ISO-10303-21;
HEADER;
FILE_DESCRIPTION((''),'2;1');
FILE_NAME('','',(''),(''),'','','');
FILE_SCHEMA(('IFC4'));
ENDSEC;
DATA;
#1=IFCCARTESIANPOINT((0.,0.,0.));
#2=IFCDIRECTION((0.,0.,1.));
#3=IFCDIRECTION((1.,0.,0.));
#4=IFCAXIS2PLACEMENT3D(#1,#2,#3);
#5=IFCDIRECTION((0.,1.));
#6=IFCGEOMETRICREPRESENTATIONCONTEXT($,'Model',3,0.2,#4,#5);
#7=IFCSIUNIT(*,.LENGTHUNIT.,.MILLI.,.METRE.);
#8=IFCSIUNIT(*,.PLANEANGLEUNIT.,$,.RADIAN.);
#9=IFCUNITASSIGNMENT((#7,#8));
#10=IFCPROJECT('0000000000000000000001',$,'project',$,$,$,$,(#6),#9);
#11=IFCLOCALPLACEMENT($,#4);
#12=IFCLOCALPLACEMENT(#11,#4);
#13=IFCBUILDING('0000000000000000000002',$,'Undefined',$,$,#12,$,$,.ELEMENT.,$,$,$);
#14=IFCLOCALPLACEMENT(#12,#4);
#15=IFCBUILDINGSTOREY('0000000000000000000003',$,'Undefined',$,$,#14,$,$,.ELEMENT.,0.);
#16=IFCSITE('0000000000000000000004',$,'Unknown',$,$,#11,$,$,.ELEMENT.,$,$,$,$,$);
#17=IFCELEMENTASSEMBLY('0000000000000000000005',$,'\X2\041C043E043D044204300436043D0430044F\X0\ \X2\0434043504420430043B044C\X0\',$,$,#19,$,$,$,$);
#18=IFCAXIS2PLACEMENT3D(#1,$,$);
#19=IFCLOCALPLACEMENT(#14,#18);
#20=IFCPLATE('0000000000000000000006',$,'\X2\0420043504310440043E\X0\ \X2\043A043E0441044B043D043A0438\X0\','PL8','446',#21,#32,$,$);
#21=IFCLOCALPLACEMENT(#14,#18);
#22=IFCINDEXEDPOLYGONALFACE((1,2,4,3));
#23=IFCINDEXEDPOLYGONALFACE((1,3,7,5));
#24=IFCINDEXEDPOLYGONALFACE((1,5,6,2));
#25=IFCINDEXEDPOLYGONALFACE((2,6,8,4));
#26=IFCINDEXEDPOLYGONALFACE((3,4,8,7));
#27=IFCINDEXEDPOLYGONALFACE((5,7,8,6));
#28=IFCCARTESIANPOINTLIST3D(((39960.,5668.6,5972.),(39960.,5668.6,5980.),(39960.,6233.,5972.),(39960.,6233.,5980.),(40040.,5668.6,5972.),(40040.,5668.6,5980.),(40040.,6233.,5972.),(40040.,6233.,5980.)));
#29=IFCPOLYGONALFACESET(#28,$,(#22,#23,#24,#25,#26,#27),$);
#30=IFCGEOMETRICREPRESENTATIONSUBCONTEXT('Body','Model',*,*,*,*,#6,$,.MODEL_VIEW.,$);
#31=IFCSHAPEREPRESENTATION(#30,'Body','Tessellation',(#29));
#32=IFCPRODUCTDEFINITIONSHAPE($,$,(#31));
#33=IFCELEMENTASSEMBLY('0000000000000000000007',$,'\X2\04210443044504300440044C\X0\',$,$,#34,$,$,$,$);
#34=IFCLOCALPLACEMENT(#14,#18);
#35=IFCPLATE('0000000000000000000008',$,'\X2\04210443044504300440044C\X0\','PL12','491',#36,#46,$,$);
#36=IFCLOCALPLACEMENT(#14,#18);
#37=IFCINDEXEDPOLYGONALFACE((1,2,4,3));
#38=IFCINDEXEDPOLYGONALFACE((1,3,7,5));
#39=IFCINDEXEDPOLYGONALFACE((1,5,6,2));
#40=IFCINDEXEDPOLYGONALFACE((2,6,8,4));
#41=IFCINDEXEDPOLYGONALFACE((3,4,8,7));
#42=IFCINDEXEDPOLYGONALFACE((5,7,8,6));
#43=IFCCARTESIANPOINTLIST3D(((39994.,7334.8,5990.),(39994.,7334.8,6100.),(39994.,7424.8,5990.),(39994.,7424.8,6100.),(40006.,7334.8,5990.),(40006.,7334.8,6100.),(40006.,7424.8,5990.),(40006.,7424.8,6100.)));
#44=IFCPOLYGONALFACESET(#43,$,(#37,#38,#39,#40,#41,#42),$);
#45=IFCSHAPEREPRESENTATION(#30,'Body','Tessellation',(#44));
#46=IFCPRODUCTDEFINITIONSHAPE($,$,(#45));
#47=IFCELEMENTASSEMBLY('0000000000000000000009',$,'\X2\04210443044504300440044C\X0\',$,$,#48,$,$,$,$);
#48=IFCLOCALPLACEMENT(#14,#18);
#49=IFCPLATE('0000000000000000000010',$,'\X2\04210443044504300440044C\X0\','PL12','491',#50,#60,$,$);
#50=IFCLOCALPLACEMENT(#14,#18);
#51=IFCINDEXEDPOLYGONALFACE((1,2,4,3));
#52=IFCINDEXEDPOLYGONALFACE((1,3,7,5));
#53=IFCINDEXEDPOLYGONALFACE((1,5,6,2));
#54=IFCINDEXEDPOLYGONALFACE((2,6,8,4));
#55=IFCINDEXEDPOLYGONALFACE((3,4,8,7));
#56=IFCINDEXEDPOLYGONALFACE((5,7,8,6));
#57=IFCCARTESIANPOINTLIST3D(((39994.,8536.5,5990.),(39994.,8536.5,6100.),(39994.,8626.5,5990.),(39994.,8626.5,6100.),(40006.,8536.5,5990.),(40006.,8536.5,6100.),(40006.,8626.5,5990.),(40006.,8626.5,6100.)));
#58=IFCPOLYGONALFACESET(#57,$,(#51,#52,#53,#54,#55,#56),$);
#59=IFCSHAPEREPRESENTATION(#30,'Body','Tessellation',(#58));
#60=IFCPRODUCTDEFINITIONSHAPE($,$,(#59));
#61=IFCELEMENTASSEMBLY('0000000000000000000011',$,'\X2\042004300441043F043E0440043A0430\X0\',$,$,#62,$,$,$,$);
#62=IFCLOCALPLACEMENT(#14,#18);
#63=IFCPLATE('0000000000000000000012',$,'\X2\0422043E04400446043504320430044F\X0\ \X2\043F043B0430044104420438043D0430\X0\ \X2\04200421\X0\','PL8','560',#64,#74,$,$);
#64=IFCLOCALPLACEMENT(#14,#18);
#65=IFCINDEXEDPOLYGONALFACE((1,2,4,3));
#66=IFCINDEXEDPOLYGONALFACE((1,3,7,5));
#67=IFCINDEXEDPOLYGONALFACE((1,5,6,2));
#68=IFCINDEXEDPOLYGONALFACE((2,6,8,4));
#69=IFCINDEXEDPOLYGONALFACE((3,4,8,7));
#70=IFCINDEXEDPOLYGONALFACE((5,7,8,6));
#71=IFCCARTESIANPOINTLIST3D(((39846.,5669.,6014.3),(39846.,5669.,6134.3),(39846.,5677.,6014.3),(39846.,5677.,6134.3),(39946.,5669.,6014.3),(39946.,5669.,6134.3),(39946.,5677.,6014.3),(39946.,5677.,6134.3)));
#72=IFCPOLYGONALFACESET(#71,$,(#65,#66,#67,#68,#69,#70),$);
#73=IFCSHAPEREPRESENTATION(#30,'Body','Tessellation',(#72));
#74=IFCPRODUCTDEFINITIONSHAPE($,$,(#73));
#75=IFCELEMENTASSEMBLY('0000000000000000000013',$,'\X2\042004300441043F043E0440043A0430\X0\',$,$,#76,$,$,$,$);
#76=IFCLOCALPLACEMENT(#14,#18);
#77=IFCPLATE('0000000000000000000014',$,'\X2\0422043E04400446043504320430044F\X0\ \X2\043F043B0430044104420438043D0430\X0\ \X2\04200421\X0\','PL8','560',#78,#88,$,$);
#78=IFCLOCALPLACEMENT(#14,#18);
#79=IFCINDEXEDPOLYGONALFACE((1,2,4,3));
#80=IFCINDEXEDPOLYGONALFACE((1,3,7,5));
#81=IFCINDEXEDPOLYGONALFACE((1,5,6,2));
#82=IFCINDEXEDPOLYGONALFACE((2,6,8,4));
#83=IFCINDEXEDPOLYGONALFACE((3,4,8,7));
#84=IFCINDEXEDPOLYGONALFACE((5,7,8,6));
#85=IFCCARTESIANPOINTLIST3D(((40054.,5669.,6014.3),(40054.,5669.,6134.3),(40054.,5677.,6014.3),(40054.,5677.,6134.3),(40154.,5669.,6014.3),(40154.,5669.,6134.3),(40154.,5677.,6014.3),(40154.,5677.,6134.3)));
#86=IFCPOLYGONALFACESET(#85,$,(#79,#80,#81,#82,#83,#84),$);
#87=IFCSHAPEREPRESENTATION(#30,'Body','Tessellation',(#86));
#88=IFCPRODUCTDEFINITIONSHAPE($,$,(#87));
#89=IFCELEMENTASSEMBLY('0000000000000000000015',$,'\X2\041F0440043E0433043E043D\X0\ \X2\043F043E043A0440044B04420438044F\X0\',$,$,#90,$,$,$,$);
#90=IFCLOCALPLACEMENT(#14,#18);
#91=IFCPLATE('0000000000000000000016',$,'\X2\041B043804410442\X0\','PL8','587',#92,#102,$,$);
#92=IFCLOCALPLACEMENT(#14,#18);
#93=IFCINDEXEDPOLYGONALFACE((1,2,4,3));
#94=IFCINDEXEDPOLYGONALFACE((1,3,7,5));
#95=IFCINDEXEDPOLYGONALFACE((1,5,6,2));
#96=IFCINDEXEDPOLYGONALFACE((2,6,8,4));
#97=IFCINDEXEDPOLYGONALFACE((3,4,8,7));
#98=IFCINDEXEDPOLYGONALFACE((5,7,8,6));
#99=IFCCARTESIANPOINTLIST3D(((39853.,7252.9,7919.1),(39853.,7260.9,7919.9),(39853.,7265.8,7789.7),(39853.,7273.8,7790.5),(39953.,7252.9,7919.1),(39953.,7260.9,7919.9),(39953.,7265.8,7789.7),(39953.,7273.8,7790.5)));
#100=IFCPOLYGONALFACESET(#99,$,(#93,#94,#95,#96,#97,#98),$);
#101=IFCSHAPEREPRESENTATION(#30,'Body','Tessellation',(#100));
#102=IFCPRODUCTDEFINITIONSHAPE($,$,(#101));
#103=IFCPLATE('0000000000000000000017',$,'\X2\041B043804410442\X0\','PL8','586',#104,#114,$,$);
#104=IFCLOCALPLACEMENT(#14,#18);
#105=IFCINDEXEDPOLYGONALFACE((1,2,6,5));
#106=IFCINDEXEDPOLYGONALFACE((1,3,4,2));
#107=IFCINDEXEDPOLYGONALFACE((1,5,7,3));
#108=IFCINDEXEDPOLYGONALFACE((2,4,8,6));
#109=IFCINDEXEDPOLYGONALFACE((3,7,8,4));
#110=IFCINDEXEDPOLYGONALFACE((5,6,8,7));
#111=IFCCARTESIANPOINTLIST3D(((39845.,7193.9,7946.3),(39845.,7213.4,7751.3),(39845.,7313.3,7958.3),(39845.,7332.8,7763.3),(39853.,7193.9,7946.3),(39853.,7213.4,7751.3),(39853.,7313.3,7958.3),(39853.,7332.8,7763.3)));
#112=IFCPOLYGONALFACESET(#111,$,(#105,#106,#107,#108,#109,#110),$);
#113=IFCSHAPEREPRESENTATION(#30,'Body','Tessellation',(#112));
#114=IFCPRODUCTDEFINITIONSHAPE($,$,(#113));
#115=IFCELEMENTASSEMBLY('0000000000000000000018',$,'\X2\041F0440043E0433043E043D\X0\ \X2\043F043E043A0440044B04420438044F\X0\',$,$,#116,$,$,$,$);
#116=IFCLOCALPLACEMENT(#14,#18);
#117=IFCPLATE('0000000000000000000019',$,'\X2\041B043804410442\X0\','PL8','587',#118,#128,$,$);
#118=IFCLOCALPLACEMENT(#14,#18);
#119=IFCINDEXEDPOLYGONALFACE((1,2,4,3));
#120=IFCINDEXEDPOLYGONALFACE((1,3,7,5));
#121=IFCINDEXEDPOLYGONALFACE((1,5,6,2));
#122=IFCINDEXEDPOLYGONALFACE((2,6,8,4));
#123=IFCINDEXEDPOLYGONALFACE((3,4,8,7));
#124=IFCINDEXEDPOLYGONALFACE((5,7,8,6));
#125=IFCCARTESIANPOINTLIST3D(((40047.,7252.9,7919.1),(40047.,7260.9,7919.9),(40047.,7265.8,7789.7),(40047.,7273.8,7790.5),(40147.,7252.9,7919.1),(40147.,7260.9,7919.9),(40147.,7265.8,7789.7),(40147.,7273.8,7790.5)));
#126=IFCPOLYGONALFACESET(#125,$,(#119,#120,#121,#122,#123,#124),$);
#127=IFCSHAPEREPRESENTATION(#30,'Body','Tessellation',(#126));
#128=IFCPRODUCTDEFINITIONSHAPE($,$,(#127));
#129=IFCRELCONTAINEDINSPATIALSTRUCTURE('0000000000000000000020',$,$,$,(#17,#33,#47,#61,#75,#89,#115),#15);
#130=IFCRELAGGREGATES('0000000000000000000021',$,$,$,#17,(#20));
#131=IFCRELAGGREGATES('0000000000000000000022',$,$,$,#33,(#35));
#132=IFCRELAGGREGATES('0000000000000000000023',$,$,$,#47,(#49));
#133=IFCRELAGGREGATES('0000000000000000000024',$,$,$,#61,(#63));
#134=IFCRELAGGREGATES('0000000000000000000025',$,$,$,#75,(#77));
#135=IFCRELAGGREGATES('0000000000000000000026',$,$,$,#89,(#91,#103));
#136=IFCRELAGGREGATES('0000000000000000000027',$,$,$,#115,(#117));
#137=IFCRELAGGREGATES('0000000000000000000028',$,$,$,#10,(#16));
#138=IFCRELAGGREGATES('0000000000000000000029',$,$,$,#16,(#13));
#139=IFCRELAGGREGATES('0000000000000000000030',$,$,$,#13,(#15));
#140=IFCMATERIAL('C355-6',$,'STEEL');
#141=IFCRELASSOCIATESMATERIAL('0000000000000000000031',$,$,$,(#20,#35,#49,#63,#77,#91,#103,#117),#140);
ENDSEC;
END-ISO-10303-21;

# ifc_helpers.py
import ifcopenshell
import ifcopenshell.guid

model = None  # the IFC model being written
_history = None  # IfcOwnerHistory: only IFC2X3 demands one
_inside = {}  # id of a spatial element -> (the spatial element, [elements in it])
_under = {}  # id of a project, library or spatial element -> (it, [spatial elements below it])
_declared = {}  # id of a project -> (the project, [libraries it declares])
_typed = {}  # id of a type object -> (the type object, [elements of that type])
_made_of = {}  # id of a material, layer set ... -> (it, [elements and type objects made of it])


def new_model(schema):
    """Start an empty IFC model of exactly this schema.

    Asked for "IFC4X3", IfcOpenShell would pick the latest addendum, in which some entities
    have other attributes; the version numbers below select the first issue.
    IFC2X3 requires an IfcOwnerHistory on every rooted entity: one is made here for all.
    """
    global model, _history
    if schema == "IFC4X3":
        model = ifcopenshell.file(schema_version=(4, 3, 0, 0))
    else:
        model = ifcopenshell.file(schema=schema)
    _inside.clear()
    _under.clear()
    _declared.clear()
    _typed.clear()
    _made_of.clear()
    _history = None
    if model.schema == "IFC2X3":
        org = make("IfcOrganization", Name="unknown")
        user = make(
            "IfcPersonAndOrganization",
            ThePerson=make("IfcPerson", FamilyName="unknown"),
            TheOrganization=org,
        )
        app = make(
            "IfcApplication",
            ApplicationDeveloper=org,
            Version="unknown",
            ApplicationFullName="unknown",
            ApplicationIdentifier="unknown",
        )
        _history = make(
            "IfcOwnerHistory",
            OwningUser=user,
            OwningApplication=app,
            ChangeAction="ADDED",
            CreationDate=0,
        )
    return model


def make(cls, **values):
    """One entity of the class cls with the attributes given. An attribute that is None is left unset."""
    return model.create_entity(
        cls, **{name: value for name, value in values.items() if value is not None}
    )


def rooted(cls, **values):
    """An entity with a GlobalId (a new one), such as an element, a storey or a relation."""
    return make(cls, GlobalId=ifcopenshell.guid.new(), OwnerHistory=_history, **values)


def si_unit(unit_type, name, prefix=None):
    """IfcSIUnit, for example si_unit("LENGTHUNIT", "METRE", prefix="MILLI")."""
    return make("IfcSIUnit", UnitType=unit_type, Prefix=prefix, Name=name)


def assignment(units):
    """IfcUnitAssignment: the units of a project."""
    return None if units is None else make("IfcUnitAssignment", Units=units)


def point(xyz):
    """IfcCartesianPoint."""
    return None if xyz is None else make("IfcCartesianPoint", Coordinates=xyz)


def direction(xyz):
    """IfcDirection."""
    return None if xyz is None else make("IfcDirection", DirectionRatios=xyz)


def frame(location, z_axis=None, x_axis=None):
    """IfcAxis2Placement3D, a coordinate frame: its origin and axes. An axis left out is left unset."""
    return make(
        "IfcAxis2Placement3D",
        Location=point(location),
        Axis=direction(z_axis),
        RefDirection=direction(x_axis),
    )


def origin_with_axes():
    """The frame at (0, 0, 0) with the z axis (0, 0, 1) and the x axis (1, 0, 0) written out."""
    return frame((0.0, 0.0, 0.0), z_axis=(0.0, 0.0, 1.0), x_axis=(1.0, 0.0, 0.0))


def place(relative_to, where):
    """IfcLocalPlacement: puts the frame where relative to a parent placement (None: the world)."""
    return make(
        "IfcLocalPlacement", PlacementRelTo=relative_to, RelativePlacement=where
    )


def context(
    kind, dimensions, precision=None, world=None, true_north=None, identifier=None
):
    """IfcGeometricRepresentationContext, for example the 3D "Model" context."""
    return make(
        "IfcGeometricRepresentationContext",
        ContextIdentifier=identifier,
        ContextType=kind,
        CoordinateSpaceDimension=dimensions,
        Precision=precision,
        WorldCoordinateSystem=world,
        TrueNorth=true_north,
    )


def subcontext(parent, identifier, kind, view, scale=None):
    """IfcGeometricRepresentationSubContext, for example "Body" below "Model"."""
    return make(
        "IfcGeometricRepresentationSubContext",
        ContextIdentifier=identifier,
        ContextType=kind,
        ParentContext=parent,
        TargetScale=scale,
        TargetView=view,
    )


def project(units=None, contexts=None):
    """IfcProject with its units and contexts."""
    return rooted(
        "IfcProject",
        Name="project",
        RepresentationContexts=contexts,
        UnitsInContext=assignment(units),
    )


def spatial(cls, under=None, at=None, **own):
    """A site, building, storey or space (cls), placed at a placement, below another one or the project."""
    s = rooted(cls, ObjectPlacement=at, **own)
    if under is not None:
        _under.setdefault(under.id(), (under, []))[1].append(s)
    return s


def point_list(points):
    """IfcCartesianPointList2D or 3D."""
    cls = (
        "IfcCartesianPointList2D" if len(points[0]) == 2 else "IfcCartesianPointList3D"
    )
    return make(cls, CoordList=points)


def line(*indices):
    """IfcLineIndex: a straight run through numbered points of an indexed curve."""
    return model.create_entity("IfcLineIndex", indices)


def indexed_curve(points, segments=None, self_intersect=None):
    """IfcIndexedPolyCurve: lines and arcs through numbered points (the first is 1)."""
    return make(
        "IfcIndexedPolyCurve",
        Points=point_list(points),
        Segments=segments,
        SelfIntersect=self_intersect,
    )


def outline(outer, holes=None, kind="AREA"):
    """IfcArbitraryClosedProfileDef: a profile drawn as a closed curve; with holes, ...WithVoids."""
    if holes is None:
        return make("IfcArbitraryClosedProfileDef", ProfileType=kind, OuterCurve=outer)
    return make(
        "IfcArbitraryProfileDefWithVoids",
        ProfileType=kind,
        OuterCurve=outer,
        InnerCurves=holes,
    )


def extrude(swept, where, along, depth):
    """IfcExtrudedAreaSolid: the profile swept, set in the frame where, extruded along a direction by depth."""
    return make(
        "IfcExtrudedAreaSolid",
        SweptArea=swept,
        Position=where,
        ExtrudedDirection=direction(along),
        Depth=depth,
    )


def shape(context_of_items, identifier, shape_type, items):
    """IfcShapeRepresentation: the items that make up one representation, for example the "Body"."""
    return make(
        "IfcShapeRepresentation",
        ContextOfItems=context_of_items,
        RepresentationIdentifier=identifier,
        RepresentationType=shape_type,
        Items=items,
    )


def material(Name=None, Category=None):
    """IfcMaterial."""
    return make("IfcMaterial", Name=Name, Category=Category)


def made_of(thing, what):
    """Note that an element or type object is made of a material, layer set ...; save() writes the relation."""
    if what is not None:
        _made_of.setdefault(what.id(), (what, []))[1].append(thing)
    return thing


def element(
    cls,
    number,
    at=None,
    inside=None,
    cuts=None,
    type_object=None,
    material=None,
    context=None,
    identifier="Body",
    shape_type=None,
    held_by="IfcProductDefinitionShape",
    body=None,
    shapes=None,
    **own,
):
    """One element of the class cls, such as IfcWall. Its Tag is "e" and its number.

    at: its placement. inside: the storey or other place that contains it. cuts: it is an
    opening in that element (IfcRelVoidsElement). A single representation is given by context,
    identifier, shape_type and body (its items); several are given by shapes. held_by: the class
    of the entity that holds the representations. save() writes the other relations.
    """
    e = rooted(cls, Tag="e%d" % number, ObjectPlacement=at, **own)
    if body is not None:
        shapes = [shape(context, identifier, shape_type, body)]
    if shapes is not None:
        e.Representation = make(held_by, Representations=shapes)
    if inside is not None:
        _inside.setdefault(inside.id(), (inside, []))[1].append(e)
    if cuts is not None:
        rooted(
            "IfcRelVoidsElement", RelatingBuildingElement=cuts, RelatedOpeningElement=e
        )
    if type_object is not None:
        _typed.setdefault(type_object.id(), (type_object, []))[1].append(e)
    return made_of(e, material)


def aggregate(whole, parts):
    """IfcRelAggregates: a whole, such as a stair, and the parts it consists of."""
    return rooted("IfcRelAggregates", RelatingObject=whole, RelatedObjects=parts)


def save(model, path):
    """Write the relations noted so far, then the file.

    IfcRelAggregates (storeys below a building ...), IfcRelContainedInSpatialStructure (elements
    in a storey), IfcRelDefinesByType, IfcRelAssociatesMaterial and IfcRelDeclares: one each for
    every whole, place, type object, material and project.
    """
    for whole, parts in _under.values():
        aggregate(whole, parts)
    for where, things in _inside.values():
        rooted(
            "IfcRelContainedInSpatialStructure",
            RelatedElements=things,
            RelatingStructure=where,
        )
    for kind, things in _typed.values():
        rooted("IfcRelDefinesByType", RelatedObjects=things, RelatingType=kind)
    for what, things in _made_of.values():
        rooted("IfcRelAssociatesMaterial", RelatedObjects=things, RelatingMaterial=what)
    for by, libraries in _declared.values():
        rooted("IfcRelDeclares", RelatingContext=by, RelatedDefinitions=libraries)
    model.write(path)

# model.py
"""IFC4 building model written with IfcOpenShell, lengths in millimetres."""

from ifc_helpers import new_model, si_unit, direction, frame, origin_with_axes, place, context, subcontext, project, spatial, line, indexed_curve, outline, extrude, material, element, aggregate, save


model = new_model("IFC4")

# Units and contexts
model_context = context("Model", 3, precision=0.2, world=origin_with_axes(), true_north=direction((0.0, 1.0)))
body_context = subcontext(model_context, "Body", "Model", "MODEL_VIEW")
ifc_project = project(units=[si_unit("LENGTHUNIT", "METRE", prefix="MILLI"), si_unit("PLANEANGLEUNIT", "RADIAN")], contexts=[model_context])

# Site, building, storey
site_placement = place(None, origin_with_axes())
site = spatial("IfcSite", under=ifc_project, at=site_placement, Name="Unknown", CompositionType="ELEMENT")
building_placement = place(site_placement, origin_with_axes())
building = spatial("IfcBuilding", under=site, at=building_placement, Name="Undefined", CompositionType="ELEMENT")
storey_placement = place(building_placement, origin_with_axes())
storey = spatial("IfcBuildingStorey", under=building, at=storey_placement, Name="Undefined", CompositionType="ELEMENT", Elevation=0.0)

# Element assembly, plate
ifc_material_1 = material(Name="C355-6", Category="STEEL")
assembly_1_placement = place(storey_placement, frame((40000.0, 5668.6, 5980.0), z_axis=(1.0, 0.0, 0.0), x_axis=(0.0, 1.0, 0.0)))
assembly_1 = element("IfcElementAssembly", 1, at=assembly_1_placement, inside=storey, Name="Монтажная деталь")
plate_1_placement = place(assembly_1_placement, frame((564.4, -4.0, -40.0), z_axis=(0.0, 1.0, 0.0), x_axis=(-1.0, 0.0, 0.0)))
plate_1 = element("IfcPlate", 2, at=plate_1_placement, material=ifc_material_1, Name="Ребро косынки", Description="PL8", ObjectType="446", context=body_context, shape_type="SolidModel", body=[
    extrude(outline(indexed_curve([(0.0, 0.0), (564.4, 0.0), (564.4, 80.0), (0.0, 80.0)], segments=[line(1, 2, 3, 4, 1)])), frame((0.0, 0.0, 4.0), z_axis=(0.0, 0.0, 1.0), x_axis=(1.0, 0.0, 0.0)), (0.0, 0.0, -1.0), 8.0),
])
aggregate(assembly_1, [plate_1])

# Element assemblies, plates
assembly_2_placement = place(storey_placement, frame((40000.0, 7334.8, 6100.0), z_axis=(-1.0, 0.0, 0.0), x_axis=(0.0, 1.0, 0.0)))
assembly_2 = element("IfcElementAssembly", 3, at=assembly_2_placement, inside=storey, Name="Сухарь")
plate_2_placement = place(assembly_2_placement, origin_with_axes())
plate_2 = element("IfcPlate", 4, at=plate_2_placement, material=ifc_material_1, Name="Сухарь", Description="PL12", ObjectType="491", context=body_context, shape_type="SolidModel", body=[
    extrude(outline(indexed_curve([(0.0, 0.0), (90.0, 0.0), (90.0, 110.0), (0.0, 110.0)], segments=[line(1, 2, 3, 4, 1)])), frame((0.0, 0.0, 6.0), z_axis=(0.0, 0.0, 1.0), x_axis=(1.0, 0.0, 0.0)), (0.0, 0.0, -1.0), 12.0),
])
aggregate(assembly_2, [plate_2])
assembly_3_placement = place(storey_placement, frame((40000.0, 8536.5, 6100.0), z_axis=(-1.0, 0.0, 0.0), x_axis=(0.0, 1.0, 0.0)))
assembly_3 = element("IfcElementAssembly", 5, at=assembly_3_placement, inside=storey, Name="Сухарь")
plate_3_placement = place(assembly_3_placement, origin_with_axes())
plate_3 = element("IfcPlate", 6, at=plate_3_placement, material=ifc_material_1, Name="Сухарь", Description="PL12", ObjectType="491", context=body_context, shape_type="SolidModel", body=[
    extrude(outline(indexed_curve([(0.0, 0.0), (90.0, 0.0), (90.0, 110.0), (0.0, 110.0)], segments=[line(1, 2, 3, 4, 1)])), frame((0.0, 0.0, 6.0), z_axis=(0.0, 0.0, 1.0), x_axis=(1.0, 0.0, 0.0)), (0.0, 0.0, -1.0), 12.0),
])
aggregate(assembly_3, [plate_3])
assembly_4_placement = place(storey_placement, frame((34000.0, 5673.0, 6074.3), z_axis=(0.0, -1.0, 0.0), x_axis=(1.0, 0.0, 0.0)))
assembly_4 = element("IfcElementAssembly", 7, at=assembly_4_placement, inside=storey, Name="Распорка")
plate_4_placement = place(assembly_4_placement, frame((5946.0, 60.0, 0.0), z_axis=(0.0, 0.0, -1.0), x_axis=(0.0, -1.0, 0.0)))
plate_4 = element("IfcPlate", 8, at=plate_4_placement, material=ifc_material_1, Name="Торцевая пластина РС", Description="PL8", ObjectType="560", context=body_context, shape_type="SolidModel", body=[
    extrude(outline(indexed_curve([(0.0, 0.0), (120.0, 0.0), (120.0, 100.0), (0.0, 100.0)], segments=[line(1, 2, 3, 4, 1)])), frame((0.0, 0.0, 4.0), z_axis=(0.0, 0.0, 1.0), x_axis=(1.0, 0.0, 0.0)), (0.0, 0.0, -1.0), 8.0),
])
aggregate(assembly_4, [plate_4])
assembly_5_placement = place(storey_placement, frame((40000.0, 5673.0, 6074.3), z_axis=(0.0, -1.0, 0.0), x_axis=(1.0, 0.0, 0.0)))
assembly_5 = element("IfcElementAssembly", 9, at=assembly_5_placement, inside=storey, Name="Распорка")
plate_5_placement = place(assembly_5_placement, frame((54.0, -60.0, 0.0), z_axis=(0.0, 0.0, -1.0), x_axis=(0.0, 1.0, 0.0)))
plate_5 = element("IfcPlate", 10, at=plate_5_placement, material=ifc_material_1, Name="Торцевая пластина РС", Description="PL8", ObjectType="560", context=body_context, shape_type="SolidModel", body=[
    extrude(outline(indexed_curve([(0.0, 0.0), (120.0, 0.0), (120.0, 100.0), (0.0, 100.0)], segments=[line(1, 2, 3, 4, 1)])), frame((0.0, 0.0, 4.0), z_axis=(0.0, 0.0, 1.0), x_axis=(1.0, 0.0, 0.0)), (0.0, 0.0, -1.0), 8.0),
])
aggregate(assembly_5, [plate_5])

# Element assemblies, plates
assembly_6_placement = place(storey_placement, frame((34000.0, 7263.3, 7854.8), z_axis=(0.0, 0.995037, 0.099504), x_axis=(1.0, 0.0, 0.0)))
assembly_6 = element("IfcElementAssembly", 11, at=assembly_6_placement, inside=storey, Name="Прогон покрытия")
plate_6_placement = place(assembly_6_placement, frame((5953.0, 65.0, 0.0), z_axis=(0.0, 0.0, 1.0), x_axis=(-1.0, 0.0, 0.0)))
plate_6 = element("IfcPlate", 12, at=plate_6_placement, material=ifc_material_1, Name="Лист", Description="PL8", ObjectType="587", context=body_context, shape_type="SolidModel", body=[
    extrude(outline(indexed_curve([(0.0, 0.0), (100.0, 0.0), (100.0, 130.0), (0.0, 130.0)], segments=[line(1, 2, 3, 4, 1)])), frame((0.0, 0.0, 4.0), z_axis=(0.0, 0.0, 1.0), x_axis=(1.0, 0.0, 0.0)), (0.0, 0.0, -1.0), 8.0),
])
plate_7_placement = place(assembly_6_placement, frame((5849.0, -98.0, 60.0), z_axis=(1.0, 0.0, 0.0), x_axis=(0.0, 0.0, -1.0)))
plate_7 = element("IfcPlate", 13, at=plate_7_placement, material=ifc_material_1, Name="Лист", Description="PL8", ObjectType="586", context=body_context, shape_type="SolidModel", body=[
    extrude(outline(indexed_curve([(0.0, 0.0), (120.0, 0.0), (120.0, 196.0), (0.0, 196.0)], segments=[line(1, 2, 3, 4, 1)])), frame((0.0, 0.0, 4.0), z_axis=(0.0, 0.0, 1.0), x_axis=(1.0, 0.0, 0.0)), (0.0, 0.0, -1.0), 8.0),
])
aggregate(assembly_6, [plate_6, plate_7])
assembly_7_placement = place(storey_placement, frame((40000.0, 7263.3, 7854.8), z_axis=(0.0, 0.995037, 0.099504), x_axis=(1.0, 0.0, 0.0)))
assembly_7 = element("IfcElementAssembly", 14, at=assembly_7_placement, inside=storey, Name="Прогон покрытия")
plate_8_placement = place(assembly_7_placement, frame((47.0, -65.0, 0.0), z_axis=(0.0, 0.0, 1.0), x_axis=(1.0, 0.0, 0.0)))
plate_8 = element("IfcPlate", 15, at=plate_8_placement, material=ifc_material_1, Name="Лист", Description="PL8", ObjectType="587", context=body_context, shape_type="SolidModel", body=[
    extrude(outline(indexed_curve([(0.0, 0.0), (100.0, 0.0), (100.0, 130.0), (0.0, 130.0)], segments=[line(1, 2, 3, 4, 1)])), frame((0.0, 0.0, 4.0), z_axis=(0.0, 0.0, 1.0), x_axis=(1.0, 0.0, 0.0)), (0.0, 0.0, -1.0), 8.0),
])
aggregate(assembly_7, [plate_8])

save(model, "model.ifc")
